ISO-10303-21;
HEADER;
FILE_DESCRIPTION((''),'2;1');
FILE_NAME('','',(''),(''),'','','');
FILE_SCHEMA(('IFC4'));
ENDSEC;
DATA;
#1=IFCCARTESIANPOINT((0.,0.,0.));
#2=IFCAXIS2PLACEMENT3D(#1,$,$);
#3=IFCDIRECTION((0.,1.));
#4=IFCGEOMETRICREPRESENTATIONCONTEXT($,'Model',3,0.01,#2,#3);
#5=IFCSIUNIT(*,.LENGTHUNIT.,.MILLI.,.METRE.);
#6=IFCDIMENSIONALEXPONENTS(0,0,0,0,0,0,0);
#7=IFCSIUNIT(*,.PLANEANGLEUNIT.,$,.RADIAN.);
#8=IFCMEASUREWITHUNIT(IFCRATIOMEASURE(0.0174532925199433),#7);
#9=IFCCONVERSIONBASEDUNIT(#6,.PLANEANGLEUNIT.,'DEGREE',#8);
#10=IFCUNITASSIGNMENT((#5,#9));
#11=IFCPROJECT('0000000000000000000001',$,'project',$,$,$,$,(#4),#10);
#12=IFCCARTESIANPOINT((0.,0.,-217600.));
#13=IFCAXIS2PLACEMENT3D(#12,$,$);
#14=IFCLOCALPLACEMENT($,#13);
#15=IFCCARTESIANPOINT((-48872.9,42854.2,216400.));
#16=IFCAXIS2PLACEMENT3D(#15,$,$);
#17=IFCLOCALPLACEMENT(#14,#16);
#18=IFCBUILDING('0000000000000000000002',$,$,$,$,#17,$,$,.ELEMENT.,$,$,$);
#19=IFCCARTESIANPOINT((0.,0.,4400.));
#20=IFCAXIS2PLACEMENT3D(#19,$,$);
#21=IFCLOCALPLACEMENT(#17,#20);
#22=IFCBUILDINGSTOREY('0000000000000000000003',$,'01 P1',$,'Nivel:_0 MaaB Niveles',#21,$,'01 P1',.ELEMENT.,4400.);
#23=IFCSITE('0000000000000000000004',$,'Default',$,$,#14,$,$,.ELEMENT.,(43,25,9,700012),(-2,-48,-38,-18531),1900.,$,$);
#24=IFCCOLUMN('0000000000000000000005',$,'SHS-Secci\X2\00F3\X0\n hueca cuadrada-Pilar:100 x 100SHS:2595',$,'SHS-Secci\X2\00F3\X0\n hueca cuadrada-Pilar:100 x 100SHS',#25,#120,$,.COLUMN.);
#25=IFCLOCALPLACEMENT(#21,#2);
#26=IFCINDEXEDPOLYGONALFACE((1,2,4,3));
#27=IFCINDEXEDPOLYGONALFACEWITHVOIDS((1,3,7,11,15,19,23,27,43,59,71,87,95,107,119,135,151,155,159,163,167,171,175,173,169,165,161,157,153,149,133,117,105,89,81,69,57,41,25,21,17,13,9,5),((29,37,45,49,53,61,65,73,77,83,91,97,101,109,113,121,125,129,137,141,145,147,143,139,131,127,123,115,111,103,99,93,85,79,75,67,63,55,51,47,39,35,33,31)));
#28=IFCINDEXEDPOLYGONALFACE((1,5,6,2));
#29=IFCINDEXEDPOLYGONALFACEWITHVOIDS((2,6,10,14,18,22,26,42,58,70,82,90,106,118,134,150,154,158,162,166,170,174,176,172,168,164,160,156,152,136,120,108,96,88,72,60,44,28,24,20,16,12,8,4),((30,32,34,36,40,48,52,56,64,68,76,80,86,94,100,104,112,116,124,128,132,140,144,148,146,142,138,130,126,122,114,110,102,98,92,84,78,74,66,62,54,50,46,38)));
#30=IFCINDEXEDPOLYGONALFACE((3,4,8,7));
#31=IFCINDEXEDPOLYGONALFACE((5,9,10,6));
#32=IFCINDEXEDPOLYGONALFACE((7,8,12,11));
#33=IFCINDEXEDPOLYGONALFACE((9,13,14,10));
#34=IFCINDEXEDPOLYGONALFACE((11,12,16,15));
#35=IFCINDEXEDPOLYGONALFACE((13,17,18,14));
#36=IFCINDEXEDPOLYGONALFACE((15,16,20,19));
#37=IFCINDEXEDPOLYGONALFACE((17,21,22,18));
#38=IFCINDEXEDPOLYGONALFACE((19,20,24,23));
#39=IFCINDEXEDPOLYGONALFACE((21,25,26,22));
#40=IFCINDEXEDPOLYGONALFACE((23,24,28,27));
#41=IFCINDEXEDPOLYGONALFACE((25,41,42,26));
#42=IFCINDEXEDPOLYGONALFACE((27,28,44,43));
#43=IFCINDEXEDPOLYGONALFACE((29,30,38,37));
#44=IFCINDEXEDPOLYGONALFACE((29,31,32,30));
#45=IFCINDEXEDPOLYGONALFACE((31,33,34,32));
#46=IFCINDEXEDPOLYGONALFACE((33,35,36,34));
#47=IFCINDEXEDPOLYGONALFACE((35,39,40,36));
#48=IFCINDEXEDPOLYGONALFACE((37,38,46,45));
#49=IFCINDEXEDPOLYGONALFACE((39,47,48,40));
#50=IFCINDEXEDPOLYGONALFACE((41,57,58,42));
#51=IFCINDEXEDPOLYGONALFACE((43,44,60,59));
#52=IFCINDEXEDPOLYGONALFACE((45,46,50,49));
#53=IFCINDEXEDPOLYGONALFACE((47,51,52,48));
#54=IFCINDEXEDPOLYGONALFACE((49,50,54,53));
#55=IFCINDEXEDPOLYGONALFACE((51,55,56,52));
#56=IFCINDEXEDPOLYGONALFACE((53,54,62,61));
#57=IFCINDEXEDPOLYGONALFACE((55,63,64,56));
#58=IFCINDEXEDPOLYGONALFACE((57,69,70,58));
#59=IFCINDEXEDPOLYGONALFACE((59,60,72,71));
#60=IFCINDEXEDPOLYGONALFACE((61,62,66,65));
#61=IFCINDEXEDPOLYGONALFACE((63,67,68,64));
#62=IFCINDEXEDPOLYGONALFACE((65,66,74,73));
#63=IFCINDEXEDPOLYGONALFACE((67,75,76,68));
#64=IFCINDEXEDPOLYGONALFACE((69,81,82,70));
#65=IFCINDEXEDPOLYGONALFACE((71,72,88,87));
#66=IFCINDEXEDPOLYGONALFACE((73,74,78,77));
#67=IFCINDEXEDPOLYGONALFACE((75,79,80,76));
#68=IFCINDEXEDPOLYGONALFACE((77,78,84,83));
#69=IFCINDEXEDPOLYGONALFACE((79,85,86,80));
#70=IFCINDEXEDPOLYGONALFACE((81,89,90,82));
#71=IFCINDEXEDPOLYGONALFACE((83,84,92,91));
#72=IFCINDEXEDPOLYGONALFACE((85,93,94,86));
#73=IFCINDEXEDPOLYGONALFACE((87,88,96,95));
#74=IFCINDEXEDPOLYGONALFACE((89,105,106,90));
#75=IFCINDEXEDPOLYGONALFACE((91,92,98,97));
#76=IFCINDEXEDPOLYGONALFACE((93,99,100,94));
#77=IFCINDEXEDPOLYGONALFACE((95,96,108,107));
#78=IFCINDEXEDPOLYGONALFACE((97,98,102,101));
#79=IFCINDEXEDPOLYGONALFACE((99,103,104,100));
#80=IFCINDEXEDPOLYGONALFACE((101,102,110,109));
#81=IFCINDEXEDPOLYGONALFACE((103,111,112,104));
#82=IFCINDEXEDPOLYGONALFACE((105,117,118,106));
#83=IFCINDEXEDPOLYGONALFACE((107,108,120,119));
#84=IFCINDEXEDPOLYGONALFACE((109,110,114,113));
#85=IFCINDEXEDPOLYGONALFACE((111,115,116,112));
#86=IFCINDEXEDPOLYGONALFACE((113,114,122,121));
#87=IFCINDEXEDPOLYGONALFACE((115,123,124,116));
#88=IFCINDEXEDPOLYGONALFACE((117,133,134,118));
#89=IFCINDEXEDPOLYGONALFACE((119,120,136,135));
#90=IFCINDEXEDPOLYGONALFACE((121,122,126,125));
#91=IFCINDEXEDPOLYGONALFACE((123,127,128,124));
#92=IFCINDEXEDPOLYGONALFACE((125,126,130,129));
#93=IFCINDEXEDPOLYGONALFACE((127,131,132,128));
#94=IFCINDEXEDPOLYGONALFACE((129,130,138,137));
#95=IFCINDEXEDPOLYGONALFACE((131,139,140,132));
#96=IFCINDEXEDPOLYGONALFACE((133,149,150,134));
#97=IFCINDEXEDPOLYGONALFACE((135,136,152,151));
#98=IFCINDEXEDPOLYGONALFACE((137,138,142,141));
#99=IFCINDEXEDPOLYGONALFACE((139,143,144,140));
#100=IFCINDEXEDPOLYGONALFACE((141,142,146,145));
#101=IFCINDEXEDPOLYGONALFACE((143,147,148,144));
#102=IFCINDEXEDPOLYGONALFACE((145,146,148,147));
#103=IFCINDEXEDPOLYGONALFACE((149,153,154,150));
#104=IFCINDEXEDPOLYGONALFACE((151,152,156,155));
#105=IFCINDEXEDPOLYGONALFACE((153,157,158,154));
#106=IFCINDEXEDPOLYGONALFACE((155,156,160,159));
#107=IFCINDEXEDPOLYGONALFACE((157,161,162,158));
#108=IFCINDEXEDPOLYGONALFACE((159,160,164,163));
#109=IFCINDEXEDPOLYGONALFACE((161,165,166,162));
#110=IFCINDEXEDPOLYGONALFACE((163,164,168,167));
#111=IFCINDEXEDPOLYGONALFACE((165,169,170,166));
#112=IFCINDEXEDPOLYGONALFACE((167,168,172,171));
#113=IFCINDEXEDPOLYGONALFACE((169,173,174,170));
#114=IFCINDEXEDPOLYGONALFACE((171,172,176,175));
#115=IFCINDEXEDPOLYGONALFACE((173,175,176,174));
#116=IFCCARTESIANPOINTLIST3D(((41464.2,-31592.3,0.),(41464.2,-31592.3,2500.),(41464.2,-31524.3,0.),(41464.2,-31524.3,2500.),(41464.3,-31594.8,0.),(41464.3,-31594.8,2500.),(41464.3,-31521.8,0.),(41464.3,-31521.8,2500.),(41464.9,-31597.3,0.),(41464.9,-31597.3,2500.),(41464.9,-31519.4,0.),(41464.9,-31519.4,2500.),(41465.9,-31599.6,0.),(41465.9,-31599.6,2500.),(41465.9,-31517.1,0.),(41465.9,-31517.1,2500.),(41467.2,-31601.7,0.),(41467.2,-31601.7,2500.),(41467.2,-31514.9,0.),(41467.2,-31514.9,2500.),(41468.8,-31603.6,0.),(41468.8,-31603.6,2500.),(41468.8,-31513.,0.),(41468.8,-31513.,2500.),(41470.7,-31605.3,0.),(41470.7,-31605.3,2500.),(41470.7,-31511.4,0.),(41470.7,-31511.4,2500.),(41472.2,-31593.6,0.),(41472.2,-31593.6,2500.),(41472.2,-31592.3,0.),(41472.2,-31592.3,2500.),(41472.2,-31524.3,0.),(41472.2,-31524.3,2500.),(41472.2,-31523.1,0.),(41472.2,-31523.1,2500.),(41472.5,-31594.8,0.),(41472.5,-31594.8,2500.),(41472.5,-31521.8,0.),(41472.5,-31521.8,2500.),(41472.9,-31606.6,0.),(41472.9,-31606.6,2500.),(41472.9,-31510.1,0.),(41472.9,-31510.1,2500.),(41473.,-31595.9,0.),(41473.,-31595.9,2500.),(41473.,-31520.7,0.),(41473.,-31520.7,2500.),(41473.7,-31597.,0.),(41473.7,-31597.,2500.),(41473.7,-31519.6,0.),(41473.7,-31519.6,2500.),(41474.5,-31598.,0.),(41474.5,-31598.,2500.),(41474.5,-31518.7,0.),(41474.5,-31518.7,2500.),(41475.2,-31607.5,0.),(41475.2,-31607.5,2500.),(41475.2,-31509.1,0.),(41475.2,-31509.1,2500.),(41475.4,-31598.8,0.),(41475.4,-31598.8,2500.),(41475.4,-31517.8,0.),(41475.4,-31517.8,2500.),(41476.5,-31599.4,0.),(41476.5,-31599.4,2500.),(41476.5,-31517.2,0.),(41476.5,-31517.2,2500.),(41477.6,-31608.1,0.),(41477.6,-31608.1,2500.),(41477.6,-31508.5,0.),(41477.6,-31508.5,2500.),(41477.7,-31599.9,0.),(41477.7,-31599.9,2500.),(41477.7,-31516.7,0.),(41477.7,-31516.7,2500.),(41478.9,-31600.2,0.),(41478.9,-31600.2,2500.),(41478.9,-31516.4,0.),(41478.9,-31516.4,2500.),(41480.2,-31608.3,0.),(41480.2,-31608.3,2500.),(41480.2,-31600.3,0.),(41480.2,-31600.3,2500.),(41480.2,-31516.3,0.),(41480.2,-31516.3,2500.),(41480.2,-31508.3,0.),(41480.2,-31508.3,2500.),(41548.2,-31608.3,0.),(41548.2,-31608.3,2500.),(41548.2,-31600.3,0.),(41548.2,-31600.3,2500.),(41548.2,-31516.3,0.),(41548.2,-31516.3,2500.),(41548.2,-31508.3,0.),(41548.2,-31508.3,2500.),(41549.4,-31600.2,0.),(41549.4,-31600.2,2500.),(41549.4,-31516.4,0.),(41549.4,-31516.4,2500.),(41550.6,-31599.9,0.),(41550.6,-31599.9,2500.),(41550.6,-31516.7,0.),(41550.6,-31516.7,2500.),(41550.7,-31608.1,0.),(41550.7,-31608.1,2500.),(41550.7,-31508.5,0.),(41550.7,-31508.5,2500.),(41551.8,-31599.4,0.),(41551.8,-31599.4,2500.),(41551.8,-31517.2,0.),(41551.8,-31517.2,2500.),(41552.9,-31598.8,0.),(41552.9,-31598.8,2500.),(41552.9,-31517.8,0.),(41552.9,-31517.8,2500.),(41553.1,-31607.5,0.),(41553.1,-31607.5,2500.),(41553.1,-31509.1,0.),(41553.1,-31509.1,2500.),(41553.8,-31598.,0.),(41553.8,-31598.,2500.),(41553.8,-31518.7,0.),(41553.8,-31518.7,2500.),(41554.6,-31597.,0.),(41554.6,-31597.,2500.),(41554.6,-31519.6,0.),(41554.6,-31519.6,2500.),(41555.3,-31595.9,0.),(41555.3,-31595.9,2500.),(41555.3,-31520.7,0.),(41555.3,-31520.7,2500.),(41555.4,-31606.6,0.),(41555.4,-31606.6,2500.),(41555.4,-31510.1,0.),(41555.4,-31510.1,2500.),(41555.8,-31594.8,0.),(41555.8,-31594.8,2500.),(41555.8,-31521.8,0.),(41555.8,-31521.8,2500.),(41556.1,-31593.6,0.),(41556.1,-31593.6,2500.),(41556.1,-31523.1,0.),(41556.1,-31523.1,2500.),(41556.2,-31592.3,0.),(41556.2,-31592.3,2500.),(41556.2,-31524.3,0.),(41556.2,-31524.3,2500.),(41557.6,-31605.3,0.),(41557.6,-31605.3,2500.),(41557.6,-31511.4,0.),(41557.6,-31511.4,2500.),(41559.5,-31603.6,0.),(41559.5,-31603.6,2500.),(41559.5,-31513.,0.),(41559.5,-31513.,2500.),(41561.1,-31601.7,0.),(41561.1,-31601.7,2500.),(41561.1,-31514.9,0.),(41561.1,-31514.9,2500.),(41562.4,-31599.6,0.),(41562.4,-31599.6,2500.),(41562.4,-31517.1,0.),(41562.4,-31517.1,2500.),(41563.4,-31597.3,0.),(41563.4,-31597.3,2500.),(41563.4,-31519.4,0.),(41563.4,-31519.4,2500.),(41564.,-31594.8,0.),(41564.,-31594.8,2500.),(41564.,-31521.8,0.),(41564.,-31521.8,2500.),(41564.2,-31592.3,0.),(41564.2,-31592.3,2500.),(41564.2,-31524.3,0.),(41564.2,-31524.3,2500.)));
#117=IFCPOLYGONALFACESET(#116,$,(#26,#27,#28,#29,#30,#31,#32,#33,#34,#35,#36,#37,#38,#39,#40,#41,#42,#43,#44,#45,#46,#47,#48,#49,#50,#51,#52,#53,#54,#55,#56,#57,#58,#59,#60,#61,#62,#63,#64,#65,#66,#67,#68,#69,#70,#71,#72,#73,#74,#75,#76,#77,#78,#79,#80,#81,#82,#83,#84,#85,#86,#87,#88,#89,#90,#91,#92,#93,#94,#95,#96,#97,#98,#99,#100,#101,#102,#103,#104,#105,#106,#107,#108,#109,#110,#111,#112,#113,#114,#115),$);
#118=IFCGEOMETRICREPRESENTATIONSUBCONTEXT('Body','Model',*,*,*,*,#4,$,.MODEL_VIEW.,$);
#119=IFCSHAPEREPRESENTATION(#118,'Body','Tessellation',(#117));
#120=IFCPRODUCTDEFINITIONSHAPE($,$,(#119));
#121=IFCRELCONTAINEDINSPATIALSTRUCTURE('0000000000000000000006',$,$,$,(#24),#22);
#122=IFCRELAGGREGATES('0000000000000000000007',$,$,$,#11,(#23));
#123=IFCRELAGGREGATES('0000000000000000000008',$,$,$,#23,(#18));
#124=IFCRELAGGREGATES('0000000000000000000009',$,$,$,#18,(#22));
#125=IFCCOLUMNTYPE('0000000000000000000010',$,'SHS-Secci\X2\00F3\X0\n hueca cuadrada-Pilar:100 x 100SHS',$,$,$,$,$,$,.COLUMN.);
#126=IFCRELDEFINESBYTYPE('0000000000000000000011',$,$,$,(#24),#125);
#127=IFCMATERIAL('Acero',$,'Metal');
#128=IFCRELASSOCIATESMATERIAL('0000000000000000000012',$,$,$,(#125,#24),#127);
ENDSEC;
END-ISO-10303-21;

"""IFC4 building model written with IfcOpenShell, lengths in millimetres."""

from ifc_helpers import new_model, entity, si_unit, converted_unit, direction, frame, origin, place, context, subcontext, project, spatial, indexed_curve, outline, extrude, source, transform, mapped, material, type_object, type_shapes, element, save


model = new_model("IFC4")

# Units and contexts
model_context = context("Model", 3, precision=0.01, world=origin(), true_north=direction((0.0, 1.0)))
body_context = subcontext(model_context, "Body", "Model", "MODEL_VIEW")
ifc_project = project(units=[si_unit("LENGTHUNIT", "METRE", prefix="MILLI"), converted_unit("PLANEANGLEUNIT", "DEGREE", entity("IfcRatioMeasure", 0.0174532925199433), si_unit("PLANEANGLEUNIT", "RADIAN"), dimensions=[0, 0, 0, 0, 0, 0, 0])], contexts=[model_context])

# Site, building, storey
site_placement = place(None, frame((0.0, 0.0, -217600.0)))
site = spatial("IfcSite", under=ifc_project, at=site_placement, Name="Default", CompositionType="ELEMENT", RefLatitude=(43, 25, 9, 700012), RefLongitude=(-2, -48, -38, -18531), RefElevation=1900.0)
building_placement = place(site_placement, frame((-48872.9, 42854.2, 216400.0)))
building = spatial("IfcBuilding", under=site, at=building_placement, CompositionType="ELEMENT")
storey_placement = place(building_placement, frame((0.0, 0.0, 4400.0)))
storey = spatial("IfcBuildingStorey", under=building, at=storey_placement, Name="01 P1", ObjectType="Nivel:_0 MaaB Niveles", LongName="01 P1", CompositionType="ELEMENT", Elevation=4400.0)

# Column
ifc_material_1 = material(Name="Acero", Category="Metal")
column_type_1 = type_object("IfcColumnType", Name="SHS-Sección hueca cuadrada-Pilar:100 x 100SHS", PredefinedType="COLUMN", material=ifc_material_1)
shared_shape_1 = source(origin(), body_context, "Body", "SweptSolid", [
    extrude(outline(indexed_curve([(-34.0, -50.0), (34.0, -50.0), (36.5, -49.8), (38.9, -49.2), (41.3, -48.3), (43.4, -46.9), (45.3, -45.3), (46.9, -43.4), (48.3, -41.3), (49.2, -38.9), (49.8, -36.5), (50.0, -34.0), (50.0, 34.0), (49.8, 36.5), (49.2, 38.9), (48.3, 41.3), (46.9, 43.4), (45.3, 45.3), (43.4, 46.9), (41.3, 48.3), (38.9, 49.2), (36.5, 49.8), (34.0, 50.0), (-34.0, 50.0), (-36.5, 49.8), (-38.9, 49.2), (-41.3, 48.3), (-43.4, 46.9), (-45.3, 45.3), (-46.9, 43.4), (-48.3, 41.3), (-49.2, 38.9), (-49.8, 36.5), (-50.0, 34.0), (-50.0, -34.0), (-49.8, -36.5), (-49.2, -38.9), (-48.3, -41.3), (-46.9, -43.4), (-45.3, -45.3), (-43.4, -46.9), (-41.3, -48.3), (-38.9, -49.2), (-36.5, -49.8), (-34.0, -50.0)], self_intersect=False), holes=[indexed_curve([(-42.0, 34.0), (-41.9, 35.3), (-41.6, 36.5), (-41.1, 37.6), (-40.5, 38.7), (-39.7, 39.7), (-38.7, 40.5), (-37.6, 41.1), (-36.5, 41.6), (-35.3, 41.9), (-34.0, 42.0), (34.0, 42.0), (35.3, 41.9), (36.5, 41.6), (37.6, 41.1), (38.7, 40.5), (39.7, 39.7), (40.5, 38.7), (41.1, 37.6), (41.6, 36.5), (41.9, 35.3), (42.0, 34.0), (42.0, -34.0), (41.9, -35.3), (41.6, -36.5), (41.1, -37.6), (40.5, -38.7), (39.7, -39.7), (38.7, -40.5), (37.6, -41.1), (36.5, -41.6), (35.3, -41.9), (34.0, -42.0), (-34.0, -42.0), (-35.3, -41.9), (-36.5, -41.6), (-37.6, -41.1), (-38.7, -40.5), (-39.7, -39.7), (-40.5, -38.7), (-41.1, -37.6), (-41.6, -36.5), (-41.9, -35.3), (-42.0, -34.0), (-42.0, 34.0)], self_intersect=False)]), frame((0.0, 0.0, 4400.0), z_axis=(0.0, 0.0, 1.0), x_axis=(0.0, 1.0, 0.0)), (0.0, 0.0, 1.0), 2500.0),
])
type_shapes(column_type_1, [shared_shape_1])
column_1_placement = place(storey_placement, frame((41514.2, -31558.3, -4400.0), z_axis=(0.0, 0.0, 1.0), x_axis=(0.0, -1.0, 0.0)))
element("IfcColumn", 1, at=column_1_placement, inside=storey, type_object=column_type_1, material=ifc_material_1, Name="SHS-Sección hueca cuadrada-Pilar:100 x 100SHS:2595", ObjectType="SHS-Sección hueca cuadrada-Pilar:100 x 100SHS", PredefinedType="COLUMN", context=body_context, shape_type="MappedRepresentation", body=[
    mapped(shared_shape_1, transform((0.0, 0.0, 0.0), scale=1.0)),
])

save(model, "model.ifc")
